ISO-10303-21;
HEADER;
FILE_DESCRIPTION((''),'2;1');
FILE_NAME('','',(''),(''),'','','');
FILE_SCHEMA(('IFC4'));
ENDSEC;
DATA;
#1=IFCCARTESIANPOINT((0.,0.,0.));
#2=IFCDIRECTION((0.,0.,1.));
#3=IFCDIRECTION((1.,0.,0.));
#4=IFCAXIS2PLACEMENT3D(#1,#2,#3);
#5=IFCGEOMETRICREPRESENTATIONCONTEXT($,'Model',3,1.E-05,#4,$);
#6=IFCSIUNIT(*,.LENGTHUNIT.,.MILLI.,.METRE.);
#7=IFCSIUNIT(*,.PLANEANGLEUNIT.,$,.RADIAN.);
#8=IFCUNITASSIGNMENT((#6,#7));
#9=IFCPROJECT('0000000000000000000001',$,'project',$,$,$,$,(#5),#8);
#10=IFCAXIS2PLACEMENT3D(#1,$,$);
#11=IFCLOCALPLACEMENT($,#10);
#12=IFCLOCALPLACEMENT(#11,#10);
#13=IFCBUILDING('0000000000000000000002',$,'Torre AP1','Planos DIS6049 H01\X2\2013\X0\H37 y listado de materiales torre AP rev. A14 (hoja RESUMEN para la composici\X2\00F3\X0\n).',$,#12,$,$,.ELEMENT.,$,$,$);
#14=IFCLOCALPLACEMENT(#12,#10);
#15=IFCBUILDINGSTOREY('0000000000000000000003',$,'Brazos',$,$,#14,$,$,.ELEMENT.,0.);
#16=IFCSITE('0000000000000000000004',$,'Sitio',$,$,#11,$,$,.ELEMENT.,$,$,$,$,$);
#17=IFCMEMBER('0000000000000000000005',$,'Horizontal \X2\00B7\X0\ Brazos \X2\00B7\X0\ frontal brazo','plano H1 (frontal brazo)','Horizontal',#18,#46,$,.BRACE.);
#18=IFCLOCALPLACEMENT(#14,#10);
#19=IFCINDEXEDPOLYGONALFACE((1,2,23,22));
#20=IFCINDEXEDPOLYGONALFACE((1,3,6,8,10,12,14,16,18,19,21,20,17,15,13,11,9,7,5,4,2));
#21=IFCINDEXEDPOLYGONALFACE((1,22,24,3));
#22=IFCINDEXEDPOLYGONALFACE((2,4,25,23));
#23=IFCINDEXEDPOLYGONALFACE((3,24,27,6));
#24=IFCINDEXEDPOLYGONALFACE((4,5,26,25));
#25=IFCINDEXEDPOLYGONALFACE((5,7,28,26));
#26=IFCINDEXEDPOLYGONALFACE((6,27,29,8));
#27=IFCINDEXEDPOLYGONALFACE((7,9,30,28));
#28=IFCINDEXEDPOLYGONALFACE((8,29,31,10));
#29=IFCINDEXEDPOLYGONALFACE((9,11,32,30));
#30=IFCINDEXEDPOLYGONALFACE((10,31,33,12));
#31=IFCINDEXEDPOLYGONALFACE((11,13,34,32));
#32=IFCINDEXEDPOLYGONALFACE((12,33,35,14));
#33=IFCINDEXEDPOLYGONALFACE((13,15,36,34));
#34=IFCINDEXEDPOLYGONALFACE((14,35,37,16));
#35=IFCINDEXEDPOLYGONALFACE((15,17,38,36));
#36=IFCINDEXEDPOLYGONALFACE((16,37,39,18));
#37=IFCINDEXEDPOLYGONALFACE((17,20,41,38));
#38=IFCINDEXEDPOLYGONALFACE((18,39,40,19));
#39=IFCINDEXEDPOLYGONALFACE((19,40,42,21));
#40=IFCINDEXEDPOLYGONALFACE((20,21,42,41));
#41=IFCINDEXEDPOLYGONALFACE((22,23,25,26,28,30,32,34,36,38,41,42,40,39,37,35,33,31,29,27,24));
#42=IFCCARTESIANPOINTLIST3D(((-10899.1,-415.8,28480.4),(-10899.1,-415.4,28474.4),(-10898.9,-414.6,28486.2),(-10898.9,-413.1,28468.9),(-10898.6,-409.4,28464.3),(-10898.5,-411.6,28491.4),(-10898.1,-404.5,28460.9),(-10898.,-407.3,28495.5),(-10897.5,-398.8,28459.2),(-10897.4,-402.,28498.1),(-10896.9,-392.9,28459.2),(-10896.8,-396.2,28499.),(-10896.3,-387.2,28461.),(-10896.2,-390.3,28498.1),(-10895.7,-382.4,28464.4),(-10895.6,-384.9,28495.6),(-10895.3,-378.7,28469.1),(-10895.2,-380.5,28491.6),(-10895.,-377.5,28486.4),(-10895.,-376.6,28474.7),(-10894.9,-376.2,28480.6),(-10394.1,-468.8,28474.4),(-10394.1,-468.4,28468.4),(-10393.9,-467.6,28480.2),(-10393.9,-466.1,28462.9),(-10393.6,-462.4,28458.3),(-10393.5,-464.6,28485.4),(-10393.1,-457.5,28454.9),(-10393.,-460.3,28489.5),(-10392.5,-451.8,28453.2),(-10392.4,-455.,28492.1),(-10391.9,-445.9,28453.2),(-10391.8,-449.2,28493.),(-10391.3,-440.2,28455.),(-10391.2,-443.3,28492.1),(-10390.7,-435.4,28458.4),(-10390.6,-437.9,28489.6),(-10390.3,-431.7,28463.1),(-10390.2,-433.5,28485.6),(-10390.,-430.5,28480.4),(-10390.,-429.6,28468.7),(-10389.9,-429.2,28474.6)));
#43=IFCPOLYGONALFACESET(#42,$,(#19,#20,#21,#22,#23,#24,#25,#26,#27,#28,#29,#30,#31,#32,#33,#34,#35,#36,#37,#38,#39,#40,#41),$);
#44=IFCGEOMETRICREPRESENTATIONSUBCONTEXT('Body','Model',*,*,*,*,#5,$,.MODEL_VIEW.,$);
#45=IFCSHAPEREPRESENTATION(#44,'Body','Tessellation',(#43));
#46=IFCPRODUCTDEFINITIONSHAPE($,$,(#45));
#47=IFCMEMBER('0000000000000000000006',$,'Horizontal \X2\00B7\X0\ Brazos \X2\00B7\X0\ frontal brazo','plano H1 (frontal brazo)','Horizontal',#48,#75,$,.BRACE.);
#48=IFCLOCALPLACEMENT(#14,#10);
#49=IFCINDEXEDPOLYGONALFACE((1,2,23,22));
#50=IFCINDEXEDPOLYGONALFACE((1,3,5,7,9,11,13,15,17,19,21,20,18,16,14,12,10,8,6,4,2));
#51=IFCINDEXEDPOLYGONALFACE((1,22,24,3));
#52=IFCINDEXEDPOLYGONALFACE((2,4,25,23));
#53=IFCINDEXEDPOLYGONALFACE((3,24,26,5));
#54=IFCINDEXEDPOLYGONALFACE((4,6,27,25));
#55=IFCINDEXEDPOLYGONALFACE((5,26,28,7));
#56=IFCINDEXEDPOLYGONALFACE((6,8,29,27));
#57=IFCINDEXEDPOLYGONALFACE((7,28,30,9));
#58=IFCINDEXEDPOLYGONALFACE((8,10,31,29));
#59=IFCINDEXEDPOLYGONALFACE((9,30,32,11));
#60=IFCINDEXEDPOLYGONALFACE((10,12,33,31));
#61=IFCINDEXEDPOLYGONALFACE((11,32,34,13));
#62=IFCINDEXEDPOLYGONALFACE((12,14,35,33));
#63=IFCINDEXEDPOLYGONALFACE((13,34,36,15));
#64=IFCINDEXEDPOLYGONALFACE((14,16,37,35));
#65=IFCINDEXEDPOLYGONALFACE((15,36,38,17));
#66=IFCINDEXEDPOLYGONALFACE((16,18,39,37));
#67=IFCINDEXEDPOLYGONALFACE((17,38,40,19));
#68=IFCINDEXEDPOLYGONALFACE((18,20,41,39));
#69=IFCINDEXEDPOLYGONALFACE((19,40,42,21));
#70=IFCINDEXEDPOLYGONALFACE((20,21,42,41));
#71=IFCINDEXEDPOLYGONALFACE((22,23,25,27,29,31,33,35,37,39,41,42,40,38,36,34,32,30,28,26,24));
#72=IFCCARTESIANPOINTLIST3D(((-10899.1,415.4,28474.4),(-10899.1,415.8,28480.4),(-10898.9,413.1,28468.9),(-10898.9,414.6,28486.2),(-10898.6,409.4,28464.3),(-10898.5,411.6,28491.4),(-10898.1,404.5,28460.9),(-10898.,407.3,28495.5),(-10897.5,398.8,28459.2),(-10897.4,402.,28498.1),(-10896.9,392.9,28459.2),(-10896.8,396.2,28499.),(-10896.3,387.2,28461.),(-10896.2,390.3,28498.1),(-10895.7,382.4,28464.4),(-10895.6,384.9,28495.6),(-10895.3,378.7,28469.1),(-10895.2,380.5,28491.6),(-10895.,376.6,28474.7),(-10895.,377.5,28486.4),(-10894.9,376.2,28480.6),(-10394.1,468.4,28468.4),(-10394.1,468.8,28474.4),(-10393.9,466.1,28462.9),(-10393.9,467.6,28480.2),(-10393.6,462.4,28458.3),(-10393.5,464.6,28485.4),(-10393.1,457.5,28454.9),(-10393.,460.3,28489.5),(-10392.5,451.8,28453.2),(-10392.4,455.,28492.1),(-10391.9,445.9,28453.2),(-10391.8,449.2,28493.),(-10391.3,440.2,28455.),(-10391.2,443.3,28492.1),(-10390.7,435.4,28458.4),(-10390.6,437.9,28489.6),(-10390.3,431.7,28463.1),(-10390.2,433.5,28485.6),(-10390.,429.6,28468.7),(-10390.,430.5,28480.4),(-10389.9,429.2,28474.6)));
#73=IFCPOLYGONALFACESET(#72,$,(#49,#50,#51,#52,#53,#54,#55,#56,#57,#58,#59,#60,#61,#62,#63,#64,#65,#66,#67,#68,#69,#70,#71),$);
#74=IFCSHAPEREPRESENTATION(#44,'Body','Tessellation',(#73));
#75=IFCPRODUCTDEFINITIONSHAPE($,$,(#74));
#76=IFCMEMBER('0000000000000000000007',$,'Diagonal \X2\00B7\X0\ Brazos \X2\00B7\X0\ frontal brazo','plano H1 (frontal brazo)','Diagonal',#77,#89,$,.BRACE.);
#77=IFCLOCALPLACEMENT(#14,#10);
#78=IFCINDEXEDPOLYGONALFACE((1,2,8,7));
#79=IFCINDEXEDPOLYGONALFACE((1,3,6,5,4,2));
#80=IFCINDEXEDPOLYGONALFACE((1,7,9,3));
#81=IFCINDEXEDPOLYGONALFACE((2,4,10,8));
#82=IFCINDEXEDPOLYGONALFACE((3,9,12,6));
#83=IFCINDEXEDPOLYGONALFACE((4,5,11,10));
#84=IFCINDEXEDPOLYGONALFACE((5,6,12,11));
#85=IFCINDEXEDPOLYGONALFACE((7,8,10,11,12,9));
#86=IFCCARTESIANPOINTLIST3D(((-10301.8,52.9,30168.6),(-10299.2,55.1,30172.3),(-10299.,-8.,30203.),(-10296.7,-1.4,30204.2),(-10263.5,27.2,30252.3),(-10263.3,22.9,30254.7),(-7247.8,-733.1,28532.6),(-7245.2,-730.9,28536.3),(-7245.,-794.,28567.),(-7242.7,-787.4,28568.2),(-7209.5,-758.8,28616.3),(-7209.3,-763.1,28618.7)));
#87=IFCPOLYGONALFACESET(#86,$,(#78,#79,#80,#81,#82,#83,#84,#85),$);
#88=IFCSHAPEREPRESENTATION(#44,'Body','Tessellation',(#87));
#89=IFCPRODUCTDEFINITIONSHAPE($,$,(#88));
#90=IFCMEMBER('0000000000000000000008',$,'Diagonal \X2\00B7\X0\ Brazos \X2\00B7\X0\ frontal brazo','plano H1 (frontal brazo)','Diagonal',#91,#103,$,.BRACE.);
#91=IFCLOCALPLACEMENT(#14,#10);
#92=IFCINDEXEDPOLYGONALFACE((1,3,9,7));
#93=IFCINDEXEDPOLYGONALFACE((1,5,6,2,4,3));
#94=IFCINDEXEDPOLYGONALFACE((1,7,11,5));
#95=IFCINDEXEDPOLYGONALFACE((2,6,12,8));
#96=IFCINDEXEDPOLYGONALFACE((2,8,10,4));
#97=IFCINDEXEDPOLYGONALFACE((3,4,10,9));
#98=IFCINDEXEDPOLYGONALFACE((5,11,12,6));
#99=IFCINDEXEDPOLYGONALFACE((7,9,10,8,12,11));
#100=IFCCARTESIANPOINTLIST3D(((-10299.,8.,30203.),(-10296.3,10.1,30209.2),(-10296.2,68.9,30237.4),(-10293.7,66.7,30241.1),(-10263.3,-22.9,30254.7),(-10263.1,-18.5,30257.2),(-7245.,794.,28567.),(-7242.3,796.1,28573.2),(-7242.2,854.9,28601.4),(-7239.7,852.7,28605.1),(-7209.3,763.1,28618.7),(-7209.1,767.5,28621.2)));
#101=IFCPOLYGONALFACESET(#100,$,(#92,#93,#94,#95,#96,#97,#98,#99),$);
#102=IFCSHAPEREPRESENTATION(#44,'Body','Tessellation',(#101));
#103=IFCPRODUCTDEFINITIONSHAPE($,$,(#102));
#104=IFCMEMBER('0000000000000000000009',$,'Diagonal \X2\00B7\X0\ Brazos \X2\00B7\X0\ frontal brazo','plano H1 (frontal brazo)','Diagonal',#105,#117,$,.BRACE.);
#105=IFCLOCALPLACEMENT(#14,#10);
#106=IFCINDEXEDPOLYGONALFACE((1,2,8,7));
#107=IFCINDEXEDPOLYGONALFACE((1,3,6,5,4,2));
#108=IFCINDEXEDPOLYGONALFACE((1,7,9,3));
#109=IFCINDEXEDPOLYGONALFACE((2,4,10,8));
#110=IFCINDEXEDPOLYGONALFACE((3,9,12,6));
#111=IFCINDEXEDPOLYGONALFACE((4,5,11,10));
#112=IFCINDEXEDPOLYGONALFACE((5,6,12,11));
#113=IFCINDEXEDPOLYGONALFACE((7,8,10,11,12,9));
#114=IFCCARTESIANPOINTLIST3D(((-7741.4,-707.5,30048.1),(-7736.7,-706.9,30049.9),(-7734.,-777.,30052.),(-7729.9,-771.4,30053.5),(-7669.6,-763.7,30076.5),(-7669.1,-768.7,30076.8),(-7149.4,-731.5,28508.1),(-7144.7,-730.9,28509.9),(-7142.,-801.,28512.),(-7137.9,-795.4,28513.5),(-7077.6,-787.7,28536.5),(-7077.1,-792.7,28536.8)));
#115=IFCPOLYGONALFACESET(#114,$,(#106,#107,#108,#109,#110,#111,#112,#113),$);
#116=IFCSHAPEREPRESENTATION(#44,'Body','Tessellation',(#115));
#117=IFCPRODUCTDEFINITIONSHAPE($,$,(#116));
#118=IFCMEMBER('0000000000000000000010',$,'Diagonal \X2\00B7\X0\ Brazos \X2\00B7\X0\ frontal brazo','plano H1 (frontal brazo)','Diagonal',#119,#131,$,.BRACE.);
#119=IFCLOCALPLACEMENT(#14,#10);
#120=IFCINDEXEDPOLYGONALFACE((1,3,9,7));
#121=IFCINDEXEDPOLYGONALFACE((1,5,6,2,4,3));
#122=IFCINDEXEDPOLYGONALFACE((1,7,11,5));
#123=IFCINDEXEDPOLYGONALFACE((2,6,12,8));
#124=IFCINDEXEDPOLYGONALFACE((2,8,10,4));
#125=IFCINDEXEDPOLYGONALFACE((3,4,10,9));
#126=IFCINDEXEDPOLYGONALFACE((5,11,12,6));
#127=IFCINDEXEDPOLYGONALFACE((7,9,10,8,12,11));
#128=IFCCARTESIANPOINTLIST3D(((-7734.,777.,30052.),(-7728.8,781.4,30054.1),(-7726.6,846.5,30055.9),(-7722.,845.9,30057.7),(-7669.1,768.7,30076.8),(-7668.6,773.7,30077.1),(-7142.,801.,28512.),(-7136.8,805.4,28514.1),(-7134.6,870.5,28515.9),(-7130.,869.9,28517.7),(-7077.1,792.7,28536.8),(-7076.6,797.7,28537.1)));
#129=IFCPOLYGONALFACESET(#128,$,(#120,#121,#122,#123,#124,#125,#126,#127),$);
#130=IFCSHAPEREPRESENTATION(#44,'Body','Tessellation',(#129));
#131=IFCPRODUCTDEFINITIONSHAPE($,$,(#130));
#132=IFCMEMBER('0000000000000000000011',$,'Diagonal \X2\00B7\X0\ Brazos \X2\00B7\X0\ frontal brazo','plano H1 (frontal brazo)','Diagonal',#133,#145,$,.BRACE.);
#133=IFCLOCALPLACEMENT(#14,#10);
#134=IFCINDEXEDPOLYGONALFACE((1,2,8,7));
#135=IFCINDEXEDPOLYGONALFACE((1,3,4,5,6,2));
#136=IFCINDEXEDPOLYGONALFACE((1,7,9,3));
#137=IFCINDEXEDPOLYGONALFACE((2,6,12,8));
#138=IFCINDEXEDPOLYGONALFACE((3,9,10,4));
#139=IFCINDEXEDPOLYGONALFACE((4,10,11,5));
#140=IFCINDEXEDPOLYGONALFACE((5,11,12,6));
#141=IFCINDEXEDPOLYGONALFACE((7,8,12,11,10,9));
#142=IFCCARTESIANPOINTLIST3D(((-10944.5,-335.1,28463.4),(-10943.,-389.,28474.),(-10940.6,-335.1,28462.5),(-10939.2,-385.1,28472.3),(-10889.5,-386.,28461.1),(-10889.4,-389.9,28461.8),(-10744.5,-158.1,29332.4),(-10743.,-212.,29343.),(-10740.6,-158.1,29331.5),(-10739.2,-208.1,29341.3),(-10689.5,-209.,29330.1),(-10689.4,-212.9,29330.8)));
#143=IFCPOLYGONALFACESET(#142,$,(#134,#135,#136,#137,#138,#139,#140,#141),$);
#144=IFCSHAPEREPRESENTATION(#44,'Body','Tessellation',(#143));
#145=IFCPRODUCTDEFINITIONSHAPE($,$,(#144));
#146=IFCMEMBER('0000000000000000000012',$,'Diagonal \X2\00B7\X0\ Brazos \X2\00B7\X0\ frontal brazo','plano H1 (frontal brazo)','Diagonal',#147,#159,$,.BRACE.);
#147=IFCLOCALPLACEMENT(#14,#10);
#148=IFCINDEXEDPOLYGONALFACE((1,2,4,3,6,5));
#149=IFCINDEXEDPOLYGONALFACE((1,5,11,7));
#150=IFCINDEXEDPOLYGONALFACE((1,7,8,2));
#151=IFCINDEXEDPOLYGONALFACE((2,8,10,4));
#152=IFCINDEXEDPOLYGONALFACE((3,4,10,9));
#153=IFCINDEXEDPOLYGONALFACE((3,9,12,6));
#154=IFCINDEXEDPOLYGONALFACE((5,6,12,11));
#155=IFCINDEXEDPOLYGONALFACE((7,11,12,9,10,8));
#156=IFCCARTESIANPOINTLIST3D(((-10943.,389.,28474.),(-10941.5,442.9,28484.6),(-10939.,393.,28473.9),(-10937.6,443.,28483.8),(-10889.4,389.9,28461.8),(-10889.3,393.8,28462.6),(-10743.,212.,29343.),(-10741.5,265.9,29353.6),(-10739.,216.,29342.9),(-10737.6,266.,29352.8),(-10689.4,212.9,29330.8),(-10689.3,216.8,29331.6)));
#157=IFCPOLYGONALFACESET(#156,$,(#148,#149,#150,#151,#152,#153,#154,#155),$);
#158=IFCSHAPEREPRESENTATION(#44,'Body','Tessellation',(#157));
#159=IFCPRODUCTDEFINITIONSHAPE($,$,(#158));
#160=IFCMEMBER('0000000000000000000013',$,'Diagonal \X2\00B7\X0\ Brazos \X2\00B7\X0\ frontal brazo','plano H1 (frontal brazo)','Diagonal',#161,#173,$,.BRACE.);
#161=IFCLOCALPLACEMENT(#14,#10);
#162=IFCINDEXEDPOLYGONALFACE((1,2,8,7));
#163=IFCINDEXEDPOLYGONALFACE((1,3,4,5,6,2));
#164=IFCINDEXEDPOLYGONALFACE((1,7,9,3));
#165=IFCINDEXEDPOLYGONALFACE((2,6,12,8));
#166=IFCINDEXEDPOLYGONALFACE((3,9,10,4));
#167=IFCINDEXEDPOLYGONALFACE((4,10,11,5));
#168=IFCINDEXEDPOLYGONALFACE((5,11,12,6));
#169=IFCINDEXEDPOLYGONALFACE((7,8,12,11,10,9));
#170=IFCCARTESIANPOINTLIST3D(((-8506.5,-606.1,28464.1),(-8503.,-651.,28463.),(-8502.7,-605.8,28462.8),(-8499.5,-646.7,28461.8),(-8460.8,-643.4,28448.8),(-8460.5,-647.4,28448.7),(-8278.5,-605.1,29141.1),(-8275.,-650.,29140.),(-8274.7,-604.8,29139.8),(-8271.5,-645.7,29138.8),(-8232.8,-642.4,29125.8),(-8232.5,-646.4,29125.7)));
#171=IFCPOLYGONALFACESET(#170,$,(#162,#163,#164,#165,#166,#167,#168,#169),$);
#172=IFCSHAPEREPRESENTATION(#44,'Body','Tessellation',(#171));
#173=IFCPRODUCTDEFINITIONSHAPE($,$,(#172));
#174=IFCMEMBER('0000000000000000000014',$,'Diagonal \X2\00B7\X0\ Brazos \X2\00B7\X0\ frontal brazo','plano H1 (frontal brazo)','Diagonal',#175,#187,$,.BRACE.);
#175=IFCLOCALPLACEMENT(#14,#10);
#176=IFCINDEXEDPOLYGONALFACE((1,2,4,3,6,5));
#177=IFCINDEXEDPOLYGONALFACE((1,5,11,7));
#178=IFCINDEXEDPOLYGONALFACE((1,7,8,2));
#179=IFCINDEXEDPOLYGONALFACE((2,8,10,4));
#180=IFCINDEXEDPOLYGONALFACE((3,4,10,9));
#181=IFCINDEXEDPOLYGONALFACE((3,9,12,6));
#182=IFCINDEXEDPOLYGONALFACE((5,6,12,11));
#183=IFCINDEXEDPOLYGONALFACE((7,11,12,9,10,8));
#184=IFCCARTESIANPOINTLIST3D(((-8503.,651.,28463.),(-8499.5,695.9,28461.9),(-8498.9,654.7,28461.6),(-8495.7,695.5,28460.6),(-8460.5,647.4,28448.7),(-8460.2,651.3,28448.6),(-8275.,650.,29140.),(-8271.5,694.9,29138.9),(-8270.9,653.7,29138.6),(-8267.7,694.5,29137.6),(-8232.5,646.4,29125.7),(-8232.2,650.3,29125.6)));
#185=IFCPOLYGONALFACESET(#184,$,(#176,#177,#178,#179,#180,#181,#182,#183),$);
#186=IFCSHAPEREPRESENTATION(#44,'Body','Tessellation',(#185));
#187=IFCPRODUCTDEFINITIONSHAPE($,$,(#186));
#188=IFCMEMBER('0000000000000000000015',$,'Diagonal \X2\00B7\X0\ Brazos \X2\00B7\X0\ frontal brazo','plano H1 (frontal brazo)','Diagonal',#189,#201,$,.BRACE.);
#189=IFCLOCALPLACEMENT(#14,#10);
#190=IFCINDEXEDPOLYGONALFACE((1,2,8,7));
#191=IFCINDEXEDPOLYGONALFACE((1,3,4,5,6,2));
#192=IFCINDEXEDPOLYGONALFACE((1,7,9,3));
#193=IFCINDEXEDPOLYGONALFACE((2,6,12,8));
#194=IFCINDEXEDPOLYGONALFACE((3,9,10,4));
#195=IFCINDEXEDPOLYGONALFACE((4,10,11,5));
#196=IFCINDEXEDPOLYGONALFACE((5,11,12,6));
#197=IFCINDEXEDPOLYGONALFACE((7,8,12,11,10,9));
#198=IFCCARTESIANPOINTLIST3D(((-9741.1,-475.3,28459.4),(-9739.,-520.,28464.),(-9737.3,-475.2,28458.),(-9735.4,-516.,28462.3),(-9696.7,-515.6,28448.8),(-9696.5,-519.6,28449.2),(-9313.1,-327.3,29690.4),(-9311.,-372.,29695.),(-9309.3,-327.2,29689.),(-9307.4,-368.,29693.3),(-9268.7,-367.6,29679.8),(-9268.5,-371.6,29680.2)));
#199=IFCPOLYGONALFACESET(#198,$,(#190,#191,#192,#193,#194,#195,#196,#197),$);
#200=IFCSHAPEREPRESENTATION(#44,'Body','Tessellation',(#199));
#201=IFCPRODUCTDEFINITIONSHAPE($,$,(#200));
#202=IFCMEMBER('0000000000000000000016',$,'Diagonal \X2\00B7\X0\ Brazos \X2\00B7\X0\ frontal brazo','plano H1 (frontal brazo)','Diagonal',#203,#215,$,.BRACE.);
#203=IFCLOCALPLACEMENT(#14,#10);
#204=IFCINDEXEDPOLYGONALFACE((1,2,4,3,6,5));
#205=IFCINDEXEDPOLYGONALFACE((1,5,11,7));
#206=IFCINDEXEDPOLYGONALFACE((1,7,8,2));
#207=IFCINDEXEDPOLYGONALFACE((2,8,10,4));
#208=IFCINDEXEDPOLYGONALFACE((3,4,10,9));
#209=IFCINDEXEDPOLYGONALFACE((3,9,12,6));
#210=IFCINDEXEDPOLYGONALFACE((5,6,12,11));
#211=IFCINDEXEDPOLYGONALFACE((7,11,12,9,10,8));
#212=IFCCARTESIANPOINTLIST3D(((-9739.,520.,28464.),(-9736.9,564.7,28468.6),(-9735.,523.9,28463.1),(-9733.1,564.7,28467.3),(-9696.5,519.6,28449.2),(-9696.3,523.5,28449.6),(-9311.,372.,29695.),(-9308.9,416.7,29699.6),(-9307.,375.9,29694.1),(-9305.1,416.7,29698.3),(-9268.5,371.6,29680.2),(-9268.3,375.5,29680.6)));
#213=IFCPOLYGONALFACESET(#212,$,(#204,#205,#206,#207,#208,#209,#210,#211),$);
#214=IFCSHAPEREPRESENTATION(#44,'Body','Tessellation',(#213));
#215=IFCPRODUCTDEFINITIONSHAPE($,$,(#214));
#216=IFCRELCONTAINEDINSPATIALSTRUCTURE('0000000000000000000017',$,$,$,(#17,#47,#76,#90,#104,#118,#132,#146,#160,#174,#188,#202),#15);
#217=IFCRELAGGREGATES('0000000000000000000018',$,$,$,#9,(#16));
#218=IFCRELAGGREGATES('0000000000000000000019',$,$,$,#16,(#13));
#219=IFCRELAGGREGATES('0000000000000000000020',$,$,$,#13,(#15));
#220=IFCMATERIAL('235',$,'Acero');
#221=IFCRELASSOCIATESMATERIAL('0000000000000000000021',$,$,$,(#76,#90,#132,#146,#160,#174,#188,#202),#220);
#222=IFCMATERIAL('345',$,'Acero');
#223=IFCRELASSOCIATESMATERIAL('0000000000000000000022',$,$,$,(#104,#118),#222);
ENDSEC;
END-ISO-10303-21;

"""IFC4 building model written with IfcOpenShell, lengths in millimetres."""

from ifc_helpers import new_model, si_unit, frame, frame_2d, origin, origin_with_axes, place, context, subcontext, project, spatial, circle, l_section, extrude, material, element, save


model = new_model("IFC4")

# Units and contexts
model_context = context("Model", 3, precision=1e-05, world=origin_with_axes())
body_context = subcontext(model_context, "Body", "Model", "MODEL_VIEW")
ifc_project = project(units=[si_unit("LENGTHUNIT", "METRE", prefix="MILLI"), si_unit("PLANEANGLEUNIT", "RADIAN")], contexts=[model_context])

# Site, building, storey
site_placement = place(None, origin())
site = spatial("IfcSite", under=ifc_project, at=site_placement, Name="Sitio", CompositionType="ELEMENT")
building_placement = place(site_placement, origin())
building = spatial("IfcBuilding", under=site, at=building_placement, Name="Torre AP1", Description="Planos DIS6049 H01–H37 y listado de materiales torre AP rev. A14 (hoja RESUMEN para la composición).", CompositionType="ELEMENT")
storey_placement = place(building_placement, origin())
storey = spatial("IfcBuildingStorey", under=building, at=storey_placement, Name="Brazos", CompositionType="ELEMENT", Elevation=0.0)

# Members
for number, where, z_axis, x_axis, name in (
    (1, (-10392.0, -449.0, 28473.0), (-0.994468, 0.10437, 0.011815), (0.104986, 0.991163, 0.081074), "Horizontal · Brazos · frontal brazo"),
    (2, (-10392.0, 449.0, 28473.0), (-0.994468, -0.10437, 0.011815), (0.104986, -0.991163, 0.081074), "Horizontal · Brazos · frontal brazo"),
):
    element("IfcMember", number, at=place(storey_placement, frame(where, z_axis=z_axis, x_axis=x_axis)), inside=storey, Name=name, Description="plano H1 (frontal brazo)", ObjectType="Horizontal", PredefinedType="BRACE", context=body_context, shape_type="SweptSolid", body=[
        extrude(circle(Radius=20.0), None, (0.0, 0.0, 1.0), 507.8),
    ])
ifc_material_1 = material(Name="235", Category="Acero")
for number, where, z_axis, x_axis, name in (
    (3, (-7245.0, -794.0, 28567.0), (-0.859644, 0.221244, 0.460503), (0.509345, 0.441284, 0.738808), "Diagonal · Brazos · frontal brazo"),
    (4, (-7245.0, 794.0, 28567.0), (-0.859644, -0.221244, 0.460503), (0.509345, -0.441284, 0.738808), "Diagonal · Brazos · frontal brazo"),
):
    element("IfcMember", number, at=place(storey_placement, frame(where, z_axis=z_axis, x_axis=x_axis)), inside=storey, material=ifc_material_1, Name=name, Description="plano H1 (frontal brazo)", ObjectType="Diagonal", PredefinedType="BRACE", context=body_context, shape_type="SweptSolid", body=[
        extrude(l_section(Depth=70.0, Width=70.0, Thickness=5.0, at=frame_2d((35.0, 35.0))), None, (0.0, 0.0, 1.0), 3552.6),
    ])
ifc_material_2 = material(Name="345", Category="Acero")
for number, where, z_axis, x_axis, name in (
    (5, (-7142.0, -801.0, 28512.0), (-0.358779, 0.014545, 0.933309), (0.927462, 0.118373, 0.354686), "Diagonal · Brazos · frontal brazo"),
    (6, (-7142.0, 801.0, 28512.0), (-0.358779, -0.014545, 0.933309), (0.927462, -0.118373, 0.354686), "Diagonal · Brazos · frontal brazo"),
):
    element("IfcMember", number, at=place(storey_placement, frame(where, z_axis=z_axis, x_axis=x_axis)), inside=storey, material=ifc_material_2, Name=name, Description="plano H1 (frontal brazo)", ObjectType="Diagonal", PredefinedType="BRACE", context=body_context, shape_type="SweptSolid", body=[
        extrude(l_section(Depth=70.0, Width=70.0, Thickness=5.0, at=frame_2d((35.0, 35.0))), None, (0.0, 0.0, 1.0), 1650.0),
    ])
for number, where, z_axis, x_axis, name in (
    (7, (-10943.0, -389.0, 28474.0), (0.219994, 0.194695, 0.955875), (0.975122, -0.016589, -0.221045), "Diagonal · Brazos · frontal brazo"),
    (8, (-10943.0, 389.0, 28474.0), (0.219994, -0.194695, 0.955875), (0.975122, 0.016589, -0.221045), "Diagonal · Brazos · frontal brazo"),
):
    element("IfcMember", number, at=place(storey_placement, frame(where, z_axis=z_axis, x_axis=x_axis)), inside=storey, material=ifc_material_1, Name=name, Description="plano H1 (frontal brazo)", ObjectType="Diagonal", PredefinedType="BRACE", context=body_context, shape_type="SweptSolid", body=[
        extrude(l_section(Depth=55.0, Width=55.0, Thickness=4.0, at=frame_2d((27.5, 27.5))), None, (0.0, 0.0, 1.0), 909.1),
    ])
for number, where, z_axis, x_axis, name in (
    (9, (-8503.0, -651.0, 28463.0), (0.319166, 0.0014, 0.947698), (0.944542, 0.081082, -0.318223), "Diagonal · Brazos · frontal brazo"),
    (10, (-8503.0, 651.0, 28463.0), (0.319166, -0.0014, 0.947698), (0.944542, -0.081082, -0.318223), "Diagonal · Brazos · frontal brazo"),
):
    element("IfcMember", number, at=place(storey_placement, frame(where, z_axis=z_axis, x_axis=x_axis)), inside=storey, material=ifc_material_1, Name=name, Description="plano H1 (frontal brazo)", ObjectType="Diagonal", PredefinedType="BRACE", context=body_context, shape_type="SweptSolid", body=[
        extrude(l_section(Depth=45.0, Width=45.0, Thickness=4.0, at=frame_2d((22.5, 22.5))), None, (0.0, 0.0, 1.0), 714.4),
    ])
for number, where, z_axis, x_axis, name in (
    (11, (-9739.0, -520.0, 28464.0), (0.326304, 0.112834, 0.938506), (0.944119, 0.009962, -0.329454), "Diagonal · Brazos · frontal brazo"),
    (12, (-9739.0, 520.0, 28464.0), (0.326304, -0.112834, 0.938506), (0.944119, -0.009962, -0.329454), "Diagonal · Brazos · frontal brazo"),
):
    element("IfcMember", number, at=place(storey_placement, frame(where, z_axis=z_axis, x_axis=x_axis)), inside=storey, material=ifc_material_1, Name=name, Description="plano H1 (frontal brazo)", ObjectType="Diagonal", PredefinedType="BRACE", context=body_context, shape_type="SweptSolid", body=[
        extrude(l_section(Depth=45.0, Width=45.0, Thickness=4.0, at=frame_2d((22.5, 22.5))), None, (0.0, 0.0, 1.0), 1311.7),
    ])

save(model, "model.ifc")
